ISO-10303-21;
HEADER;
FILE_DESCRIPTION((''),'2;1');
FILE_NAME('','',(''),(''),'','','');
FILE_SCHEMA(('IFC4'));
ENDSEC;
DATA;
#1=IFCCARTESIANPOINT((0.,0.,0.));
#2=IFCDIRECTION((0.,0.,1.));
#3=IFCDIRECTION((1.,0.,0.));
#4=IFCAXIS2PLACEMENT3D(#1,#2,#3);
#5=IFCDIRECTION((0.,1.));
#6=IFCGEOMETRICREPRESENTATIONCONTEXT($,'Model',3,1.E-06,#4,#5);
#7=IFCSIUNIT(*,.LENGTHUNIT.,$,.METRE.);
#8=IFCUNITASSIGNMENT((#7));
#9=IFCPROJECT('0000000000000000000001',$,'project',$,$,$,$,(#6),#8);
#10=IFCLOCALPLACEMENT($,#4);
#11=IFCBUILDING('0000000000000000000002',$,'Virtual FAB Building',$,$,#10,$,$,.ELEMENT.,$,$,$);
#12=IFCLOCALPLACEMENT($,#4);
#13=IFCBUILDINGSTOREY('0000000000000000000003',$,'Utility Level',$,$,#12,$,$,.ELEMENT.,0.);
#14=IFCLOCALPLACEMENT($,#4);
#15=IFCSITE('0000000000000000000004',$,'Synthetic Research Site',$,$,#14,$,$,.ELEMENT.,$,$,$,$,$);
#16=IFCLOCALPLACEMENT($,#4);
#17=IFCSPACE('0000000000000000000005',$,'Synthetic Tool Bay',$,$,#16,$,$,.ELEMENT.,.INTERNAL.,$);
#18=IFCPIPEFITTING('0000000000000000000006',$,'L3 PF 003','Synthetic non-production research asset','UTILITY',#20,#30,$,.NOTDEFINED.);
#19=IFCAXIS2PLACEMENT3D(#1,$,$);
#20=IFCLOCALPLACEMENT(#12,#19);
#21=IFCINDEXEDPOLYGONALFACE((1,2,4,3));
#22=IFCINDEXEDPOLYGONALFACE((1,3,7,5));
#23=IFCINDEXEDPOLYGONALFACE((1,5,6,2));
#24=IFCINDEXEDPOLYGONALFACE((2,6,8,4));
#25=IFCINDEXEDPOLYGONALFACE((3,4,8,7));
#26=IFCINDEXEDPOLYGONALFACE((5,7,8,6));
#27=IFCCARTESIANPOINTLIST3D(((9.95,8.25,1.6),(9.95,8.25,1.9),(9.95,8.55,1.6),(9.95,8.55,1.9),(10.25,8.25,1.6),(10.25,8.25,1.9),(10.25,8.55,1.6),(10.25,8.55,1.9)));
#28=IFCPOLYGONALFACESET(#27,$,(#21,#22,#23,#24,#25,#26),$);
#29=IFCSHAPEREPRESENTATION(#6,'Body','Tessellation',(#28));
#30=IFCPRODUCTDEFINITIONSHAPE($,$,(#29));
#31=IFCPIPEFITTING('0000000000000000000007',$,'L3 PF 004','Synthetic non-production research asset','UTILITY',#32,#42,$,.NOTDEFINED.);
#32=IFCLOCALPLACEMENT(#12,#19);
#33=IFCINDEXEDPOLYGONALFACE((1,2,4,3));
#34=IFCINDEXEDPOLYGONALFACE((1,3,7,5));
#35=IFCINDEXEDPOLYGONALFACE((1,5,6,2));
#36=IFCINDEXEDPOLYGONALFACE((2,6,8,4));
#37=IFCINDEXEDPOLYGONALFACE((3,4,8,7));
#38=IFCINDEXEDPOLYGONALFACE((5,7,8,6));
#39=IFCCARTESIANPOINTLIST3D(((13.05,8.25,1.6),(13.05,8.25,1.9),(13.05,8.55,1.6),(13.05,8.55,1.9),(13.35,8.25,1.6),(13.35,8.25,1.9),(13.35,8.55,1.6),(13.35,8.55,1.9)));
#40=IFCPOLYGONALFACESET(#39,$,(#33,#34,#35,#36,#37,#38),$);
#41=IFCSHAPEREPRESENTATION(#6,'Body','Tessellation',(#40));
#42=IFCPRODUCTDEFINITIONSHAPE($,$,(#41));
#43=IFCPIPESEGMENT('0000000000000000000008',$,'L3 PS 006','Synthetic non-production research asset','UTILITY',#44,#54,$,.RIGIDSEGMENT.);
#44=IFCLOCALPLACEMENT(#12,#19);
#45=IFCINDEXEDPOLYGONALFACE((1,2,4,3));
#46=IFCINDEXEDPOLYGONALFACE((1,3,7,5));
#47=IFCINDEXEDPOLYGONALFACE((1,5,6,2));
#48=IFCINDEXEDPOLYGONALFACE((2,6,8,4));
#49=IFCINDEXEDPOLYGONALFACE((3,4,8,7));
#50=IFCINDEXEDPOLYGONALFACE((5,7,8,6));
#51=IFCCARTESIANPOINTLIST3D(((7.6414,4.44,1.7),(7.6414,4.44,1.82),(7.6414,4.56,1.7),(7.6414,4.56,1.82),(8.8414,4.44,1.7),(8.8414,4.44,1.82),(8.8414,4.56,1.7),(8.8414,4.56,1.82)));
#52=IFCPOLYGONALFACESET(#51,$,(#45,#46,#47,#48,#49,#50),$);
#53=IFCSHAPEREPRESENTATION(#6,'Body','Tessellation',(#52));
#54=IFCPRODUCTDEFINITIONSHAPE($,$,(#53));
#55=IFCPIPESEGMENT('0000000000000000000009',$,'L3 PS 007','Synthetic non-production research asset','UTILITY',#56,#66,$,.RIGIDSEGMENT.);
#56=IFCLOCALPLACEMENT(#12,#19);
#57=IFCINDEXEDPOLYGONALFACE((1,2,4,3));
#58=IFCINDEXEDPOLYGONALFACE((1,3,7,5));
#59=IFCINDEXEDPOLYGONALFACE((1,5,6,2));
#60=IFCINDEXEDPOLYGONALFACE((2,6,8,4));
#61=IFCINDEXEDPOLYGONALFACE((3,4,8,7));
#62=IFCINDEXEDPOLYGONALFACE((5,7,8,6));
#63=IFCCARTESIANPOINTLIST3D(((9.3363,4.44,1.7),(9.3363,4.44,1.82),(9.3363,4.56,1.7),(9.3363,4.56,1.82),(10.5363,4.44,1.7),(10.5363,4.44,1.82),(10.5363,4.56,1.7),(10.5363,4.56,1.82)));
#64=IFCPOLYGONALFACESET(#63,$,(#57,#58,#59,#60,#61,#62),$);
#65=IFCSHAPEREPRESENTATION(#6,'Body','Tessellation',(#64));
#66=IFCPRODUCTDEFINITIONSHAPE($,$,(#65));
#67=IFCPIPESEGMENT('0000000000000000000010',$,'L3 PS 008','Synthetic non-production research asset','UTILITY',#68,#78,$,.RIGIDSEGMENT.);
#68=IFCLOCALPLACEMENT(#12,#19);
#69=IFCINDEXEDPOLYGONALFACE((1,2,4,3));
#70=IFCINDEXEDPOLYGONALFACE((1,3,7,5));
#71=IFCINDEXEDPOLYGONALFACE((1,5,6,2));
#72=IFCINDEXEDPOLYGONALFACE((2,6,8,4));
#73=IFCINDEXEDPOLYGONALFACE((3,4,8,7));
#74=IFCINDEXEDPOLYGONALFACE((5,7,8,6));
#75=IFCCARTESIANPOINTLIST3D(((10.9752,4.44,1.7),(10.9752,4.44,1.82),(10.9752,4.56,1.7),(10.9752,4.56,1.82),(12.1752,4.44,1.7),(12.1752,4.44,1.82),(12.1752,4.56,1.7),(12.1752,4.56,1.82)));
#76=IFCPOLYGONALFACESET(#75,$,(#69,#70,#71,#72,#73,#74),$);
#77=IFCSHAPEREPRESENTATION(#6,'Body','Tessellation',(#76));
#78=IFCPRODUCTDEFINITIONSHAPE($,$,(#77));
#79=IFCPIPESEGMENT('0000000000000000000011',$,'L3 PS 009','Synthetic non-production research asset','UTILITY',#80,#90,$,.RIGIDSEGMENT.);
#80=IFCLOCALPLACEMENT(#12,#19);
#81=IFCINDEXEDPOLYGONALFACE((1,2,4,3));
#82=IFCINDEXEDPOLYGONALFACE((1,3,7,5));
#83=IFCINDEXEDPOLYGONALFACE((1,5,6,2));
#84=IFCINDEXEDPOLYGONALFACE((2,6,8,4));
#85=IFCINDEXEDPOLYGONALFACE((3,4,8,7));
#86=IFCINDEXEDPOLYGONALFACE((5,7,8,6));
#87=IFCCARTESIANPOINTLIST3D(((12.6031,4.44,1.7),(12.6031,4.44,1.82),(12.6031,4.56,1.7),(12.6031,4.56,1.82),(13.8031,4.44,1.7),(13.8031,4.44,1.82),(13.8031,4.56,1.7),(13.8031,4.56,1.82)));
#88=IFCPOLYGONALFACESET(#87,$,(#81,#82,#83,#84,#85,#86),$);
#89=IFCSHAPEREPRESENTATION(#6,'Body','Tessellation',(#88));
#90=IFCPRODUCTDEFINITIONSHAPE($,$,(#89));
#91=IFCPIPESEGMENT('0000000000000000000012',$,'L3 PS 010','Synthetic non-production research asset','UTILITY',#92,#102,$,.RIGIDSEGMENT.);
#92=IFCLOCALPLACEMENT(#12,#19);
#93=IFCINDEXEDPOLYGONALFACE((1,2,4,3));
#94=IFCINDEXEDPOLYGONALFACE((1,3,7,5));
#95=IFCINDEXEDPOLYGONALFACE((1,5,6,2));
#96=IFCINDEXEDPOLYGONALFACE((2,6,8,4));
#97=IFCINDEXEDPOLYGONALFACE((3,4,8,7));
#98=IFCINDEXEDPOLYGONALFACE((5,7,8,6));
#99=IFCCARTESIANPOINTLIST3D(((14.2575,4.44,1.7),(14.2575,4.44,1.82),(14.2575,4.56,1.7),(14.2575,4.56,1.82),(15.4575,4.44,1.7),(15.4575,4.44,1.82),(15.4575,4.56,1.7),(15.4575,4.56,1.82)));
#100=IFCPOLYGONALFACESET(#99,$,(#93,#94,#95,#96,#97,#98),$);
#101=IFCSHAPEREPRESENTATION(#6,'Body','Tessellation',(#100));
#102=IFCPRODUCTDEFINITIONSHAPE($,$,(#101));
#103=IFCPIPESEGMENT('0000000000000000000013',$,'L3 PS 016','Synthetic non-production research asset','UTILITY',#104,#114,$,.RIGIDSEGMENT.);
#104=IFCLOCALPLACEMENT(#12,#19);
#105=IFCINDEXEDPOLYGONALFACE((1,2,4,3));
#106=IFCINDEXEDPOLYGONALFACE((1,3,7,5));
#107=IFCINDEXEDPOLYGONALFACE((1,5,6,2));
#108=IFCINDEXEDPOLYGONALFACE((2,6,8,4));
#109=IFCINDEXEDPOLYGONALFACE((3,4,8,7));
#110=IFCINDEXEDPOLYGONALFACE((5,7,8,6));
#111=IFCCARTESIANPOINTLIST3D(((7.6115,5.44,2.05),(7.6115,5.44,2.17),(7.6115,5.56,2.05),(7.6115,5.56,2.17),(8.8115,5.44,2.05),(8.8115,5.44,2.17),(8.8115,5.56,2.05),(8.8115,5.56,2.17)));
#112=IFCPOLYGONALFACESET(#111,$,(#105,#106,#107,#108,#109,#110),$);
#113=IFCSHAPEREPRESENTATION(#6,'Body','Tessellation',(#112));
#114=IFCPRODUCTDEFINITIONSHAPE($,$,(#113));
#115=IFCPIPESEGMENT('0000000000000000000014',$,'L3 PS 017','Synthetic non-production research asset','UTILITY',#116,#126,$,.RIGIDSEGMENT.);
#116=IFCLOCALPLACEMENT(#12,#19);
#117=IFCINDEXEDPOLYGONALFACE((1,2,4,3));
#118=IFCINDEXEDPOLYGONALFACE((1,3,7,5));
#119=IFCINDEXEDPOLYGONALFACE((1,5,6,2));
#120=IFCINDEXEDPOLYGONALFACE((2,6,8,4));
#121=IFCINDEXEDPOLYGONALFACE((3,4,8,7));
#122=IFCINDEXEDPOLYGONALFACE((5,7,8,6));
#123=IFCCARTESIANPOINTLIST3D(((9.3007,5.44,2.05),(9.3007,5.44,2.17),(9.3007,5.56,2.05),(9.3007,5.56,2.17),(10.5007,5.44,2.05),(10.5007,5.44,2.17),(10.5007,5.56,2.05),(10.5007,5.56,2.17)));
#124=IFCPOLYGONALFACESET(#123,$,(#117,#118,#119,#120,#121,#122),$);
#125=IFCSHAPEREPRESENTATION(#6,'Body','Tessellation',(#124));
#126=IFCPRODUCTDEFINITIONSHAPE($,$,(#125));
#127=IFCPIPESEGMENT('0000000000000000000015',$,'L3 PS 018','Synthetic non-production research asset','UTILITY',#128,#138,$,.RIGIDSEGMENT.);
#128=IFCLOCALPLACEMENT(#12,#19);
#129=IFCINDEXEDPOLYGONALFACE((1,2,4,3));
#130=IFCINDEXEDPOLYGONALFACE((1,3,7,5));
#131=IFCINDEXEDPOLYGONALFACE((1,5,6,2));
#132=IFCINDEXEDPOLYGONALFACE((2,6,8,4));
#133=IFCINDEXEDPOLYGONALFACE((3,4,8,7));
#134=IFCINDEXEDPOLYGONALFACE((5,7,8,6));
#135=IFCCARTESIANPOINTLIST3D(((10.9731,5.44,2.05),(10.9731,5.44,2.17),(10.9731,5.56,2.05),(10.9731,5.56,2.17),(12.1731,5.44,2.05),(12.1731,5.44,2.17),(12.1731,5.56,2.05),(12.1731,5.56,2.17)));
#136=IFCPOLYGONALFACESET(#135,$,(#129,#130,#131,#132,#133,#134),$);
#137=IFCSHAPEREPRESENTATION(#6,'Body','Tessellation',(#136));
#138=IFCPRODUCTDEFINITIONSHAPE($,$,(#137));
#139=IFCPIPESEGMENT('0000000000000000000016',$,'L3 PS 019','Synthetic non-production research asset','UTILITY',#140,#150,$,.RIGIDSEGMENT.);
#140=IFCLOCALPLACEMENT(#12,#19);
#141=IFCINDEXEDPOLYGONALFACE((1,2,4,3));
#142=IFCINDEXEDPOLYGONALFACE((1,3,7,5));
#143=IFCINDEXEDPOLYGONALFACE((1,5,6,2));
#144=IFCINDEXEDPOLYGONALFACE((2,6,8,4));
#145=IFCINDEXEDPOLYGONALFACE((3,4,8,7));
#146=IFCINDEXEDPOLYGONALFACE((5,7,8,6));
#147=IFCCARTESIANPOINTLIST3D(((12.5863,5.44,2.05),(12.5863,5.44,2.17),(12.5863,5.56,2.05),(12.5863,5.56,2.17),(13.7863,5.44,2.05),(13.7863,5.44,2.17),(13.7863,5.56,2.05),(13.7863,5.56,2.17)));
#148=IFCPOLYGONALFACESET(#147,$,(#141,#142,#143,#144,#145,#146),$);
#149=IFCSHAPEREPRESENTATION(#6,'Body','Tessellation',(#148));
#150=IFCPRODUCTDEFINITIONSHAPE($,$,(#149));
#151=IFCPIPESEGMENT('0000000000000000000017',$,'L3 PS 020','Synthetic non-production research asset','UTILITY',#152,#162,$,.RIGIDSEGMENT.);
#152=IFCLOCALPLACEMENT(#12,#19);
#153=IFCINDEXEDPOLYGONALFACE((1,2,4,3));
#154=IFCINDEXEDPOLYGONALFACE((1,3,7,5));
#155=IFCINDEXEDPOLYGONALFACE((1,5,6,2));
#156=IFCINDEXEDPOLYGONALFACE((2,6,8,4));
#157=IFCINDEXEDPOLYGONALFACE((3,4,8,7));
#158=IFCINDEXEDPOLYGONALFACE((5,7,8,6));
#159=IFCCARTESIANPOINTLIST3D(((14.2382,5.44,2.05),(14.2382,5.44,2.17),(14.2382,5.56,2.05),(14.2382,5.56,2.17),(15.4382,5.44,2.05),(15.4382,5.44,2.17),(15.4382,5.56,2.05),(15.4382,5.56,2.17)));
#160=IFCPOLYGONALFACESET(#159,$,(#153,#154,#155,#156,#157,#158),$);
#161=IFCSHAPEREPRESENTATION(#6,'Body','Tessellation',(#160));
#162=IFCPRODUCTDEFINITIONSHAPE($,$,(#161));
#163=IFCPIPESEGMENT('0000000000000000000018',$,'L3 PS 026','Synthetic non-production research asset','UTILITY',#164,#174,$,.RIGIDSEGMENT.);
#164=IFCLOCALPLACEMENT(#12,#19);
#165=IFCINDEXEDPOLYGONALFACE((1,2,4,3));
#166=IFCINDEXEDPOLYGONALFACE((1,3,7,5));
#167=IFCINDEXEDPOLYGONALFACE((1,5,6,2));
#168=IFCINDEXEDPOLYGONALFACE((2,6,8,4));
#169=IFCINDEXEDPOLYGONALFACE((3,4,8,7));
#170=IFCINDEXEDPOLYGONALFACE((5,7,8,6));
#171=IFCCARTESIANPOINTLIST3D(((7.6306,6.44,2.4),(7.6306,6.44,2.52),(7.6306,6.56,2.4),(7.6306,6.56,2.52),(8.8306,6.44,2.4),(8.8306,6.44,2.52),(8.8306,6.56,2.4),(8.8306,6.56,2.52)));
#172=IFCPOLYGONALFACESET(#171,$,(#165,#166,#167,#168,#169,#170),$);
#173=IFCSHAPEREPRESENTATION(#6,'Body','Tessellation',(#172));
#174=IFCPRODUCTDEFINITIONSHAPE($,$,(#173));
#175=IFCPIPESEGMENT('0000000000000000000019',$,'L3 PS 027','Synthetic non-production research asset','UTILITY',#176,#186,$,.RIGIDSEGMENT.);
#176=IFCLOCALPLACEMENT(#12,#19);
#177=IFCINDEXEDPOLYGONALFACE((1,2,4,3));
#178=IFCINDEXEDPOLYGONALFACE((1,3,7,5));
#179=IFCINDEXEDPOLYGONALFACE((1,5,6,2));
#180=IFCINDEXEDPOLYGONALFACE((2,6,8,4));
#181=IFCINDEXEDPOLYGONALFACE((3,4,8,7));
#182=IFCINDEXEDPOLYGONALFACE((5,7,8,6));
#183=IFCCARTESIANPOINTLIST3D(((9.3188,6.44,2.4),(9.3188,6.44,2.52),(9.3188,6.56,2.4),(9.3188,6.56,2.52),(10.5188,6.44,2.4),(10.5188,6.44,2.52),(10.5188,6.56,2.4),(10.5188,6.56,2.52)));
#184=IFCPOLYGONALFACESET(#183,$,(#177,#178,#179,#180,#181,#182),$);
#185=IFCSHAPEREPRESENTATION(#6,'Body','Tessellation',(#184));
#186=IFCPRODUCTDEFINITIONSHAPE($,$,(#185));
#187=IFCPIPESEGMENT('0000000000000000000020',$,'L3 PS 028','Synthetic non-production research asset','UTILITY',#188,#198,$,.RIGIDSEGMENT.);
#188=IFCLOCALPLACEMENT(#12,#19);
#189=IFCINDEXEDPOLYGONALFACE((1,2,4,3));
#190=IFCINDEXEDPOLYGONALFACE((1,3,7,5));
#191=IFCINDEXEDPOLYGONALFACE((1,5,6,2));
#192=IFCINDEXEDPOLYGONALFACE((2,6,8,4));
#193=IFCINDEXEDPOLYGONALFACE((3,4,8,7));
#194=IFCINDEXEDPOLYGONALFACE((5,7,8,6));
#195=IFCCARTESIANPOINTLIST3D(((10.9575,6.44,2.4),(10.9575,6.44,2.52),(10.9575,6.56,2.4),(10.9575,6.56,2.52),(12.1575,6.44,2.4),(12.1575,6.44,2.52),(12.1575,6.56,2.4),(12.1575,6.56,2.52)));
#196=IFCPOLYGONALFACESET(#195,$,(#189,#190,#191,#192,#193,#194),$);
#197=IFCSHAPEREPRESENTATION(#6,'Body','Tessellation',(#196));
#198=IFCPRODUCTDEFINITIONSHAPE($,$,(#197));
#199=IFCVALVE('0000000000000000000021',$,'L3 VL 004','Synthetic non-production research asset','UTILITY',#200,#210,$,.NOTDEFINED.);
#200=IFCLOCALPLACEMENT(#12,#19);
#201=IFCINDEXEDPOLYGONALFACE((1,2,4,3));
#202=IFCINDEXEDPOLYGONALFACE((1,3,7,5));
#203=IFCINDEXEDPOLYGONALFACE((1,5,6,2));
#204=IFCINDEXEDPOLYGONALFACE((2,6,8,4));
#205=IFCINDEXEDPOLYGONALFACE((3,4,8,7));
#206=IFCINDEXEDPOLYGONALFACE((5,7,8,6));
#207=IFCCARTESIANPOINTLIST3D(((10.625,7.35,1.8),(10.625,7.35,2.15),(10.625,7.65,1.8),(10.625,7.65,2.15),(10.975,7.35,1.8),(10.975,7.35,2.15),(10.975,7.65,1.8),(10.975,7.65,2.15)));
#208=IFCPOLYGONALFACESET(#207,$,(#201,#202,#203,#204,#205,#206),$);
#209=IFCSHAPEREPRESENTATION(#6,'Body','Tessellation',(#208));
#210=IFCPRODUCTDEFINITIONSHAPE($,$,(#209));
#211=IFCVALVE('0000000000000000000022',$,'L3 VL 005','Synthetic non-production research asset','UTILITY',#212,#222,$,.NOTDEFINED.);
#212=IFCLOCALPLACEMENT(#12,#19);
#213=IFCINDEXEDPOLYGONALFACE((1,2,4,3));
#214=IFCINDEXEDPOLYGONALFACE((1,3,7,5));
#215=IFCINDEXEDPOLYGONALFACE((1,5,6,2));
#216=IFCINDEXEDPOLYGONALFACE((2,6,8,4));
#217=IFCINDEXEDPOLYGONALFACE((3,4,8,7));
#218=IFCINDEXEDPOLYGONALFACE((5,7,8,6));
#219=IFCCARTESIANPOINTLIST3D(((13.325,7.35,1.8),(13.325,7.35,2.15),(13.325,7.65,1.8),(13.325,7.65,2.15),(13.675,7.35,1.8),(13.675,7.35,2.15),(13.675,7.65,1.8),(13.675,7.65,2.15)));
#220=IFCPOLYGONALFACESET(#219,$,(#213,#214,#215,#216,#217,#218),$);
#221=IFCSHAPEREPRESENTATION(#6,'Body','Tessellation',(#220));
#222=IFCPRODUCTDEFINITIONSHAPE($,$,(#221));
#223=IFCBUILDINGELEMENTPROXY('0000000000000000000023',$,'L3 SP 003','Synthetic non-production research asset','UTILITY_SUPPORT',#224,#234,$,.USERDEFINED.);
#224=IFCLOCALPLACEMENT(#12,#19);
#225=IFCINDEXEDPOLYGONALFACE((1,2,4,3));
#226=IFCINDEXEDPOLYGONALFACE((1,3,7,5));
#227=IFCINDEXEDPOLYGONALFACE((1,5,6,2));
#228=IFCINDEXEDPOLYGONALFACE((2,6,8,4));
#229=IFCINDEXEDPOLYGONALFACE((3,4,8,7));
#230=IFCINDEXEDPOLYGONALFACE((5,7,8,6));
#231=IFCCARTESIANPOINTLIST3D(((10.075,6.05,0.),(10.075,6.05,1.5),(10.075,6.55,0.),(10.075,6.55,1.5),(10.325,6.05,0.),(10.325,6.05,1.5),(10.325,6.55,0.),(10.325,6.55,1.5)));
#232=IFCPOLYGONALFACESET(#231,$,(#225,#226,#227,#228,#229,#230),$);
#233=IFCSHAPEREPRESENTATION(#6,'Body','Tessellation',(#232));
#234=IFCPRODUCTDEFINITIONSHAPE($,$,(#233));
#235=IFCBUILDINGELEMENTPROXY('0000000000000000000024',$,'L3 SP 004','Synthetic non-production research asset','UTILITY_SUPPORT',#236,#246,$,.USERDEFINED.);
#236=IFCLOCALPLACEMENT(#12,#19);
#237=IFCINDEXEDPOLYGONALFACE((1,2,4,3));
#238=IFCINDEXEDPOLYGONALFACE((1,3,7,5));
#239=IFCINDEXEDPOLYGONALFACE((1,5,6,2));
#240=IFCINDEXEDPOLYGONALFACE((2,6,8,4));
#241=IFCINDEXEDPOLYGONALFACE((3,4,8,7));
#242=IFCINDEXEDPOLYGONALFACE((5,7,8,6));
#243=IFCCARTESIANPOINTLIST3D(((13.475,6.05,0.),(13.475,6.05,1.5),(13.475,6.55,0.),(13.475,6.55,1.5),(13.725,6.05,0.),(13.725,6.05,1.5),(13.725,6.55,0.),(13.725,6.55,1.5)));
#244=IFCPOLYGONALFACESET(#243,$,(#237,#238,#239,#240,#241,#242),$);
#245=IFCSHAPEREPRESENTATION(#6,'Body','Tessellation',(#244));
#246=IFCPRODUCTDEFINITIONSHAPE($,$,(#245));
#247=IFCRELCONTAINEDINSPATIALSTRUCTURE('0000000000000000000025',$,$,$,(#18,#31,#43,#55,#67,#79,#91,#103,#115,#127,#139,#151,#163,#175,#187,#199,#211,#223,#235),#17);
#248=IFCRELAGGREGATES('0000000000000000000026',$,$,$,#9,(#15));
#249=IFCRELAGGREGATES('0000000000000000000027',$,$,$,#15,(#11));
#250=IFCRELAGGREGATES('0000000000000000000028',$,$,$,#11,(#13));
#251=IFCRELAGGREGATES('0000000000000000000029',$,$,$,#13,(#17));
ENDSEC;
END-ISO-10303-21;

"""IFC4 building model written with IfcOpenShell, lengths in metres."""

from ifc_helpers import new_model, si_unit, direction, frame, origin_with_axes, origin_2d_with_axis, place, context, project, spatial, rectangle, extrude, element, save


model = new_model("IFC4")

# Units and contexts
model_context = context("Model", 3, precision=1e-06, world=origin_with_axes(), true_north=direction((0.0, 1.0)))
ifc_project = project(units=[si_unit("LENGTHUNIT", "METRE")], contexts=[model_context])

# Site, building, storey, space
site_placement = place(None, origin_with_axes())
site = spatial("IfcSite", under=ifc_project, at=site_placement, Name="Synthetic Research Site", CompositionType="ELEMENT")
building_placement = place(None, origin_with_axes())
building = spatial("IfcBuilding", under=site, at=building_placement, Name="Virtual FAB Building", CompositionType="ELEMENT")
storey_placement = place(None, origin_with_axes())
storey = spatial("IfcBuildingStorey", under=building, at=storey_placement, Name="Utility Level", CompositionType="ELEMENT", Elevation=0.0)
space_placement = place(None, origin_with_axes())
space = spatial("IfcSpace", under=storey, at=space_placement, Name="Synthetic Tool Bay", CompositionType="ELEMENT", PredefinedType="INTERNAL")

# Pipe fittings
for number, where, z_axis, x_axis, name in (
    (1, (10.1, 8.4, 1.6), (0.0, 0.0, 1.0), (1.0, 0.0, 0.0), "L3 PF 003"),
    (2, (13.2, 8.4, 1.6), (0.0, 0.0, 1.0), (1.0, 0.0, 0.0), "L3 PF 004"),
):
    element("IfcPipeFitting", number, at=place(None, frame(where, z_axis=z_axis, x_axis=x_axis)), inside=space, Name=name, Description="Synthetic non-production research asset", ObjectType="UTILITY", PredefinedType="NOTDEFINED", context=model_context, shape_type="SweptSolid", body=[
        extrude(rectangle(XDim=0.3, YDim=0.3, at=origin_2d_with_axis()), origin_with_axes(), (0.0, 0.0, 1.0), 0.3),
    ])

# Pipe segments
for number, where, z_axis, x_axis, name in (
    (3, (8.2414, 4.5, 1.7), (0.0, 0.0, 1.0), (1.0, 0.0, 0.0), "L3 PS 006"),
    (4, (9.9363, 4.5, 1.7), (0.0, 0.0, 1.0), (1.0, 0.0, 0.0), "L3 PS 007"),
    (5, (11.5752, 4.5, 1.7), (0.0, 0.0, 1.0), (1.0, 0.0, 0.0), "L3 PS 008"),
    (6, (13.2031, 4.5, 1.7), (0.0, 0.0, 1.0), (1.0, 0.0, 0.0), "L3 PS 009"),
    (7, (14.8575, 4.5, 1.7), (0.0, 0.0, 1.0), (1.0, 0.0, 0.0), "L3 PS 010"),
    (8, (8.2115, 5.5, 2.05), (0.0, 0.0, 1.0), (1.0, 0.0, 0.0), "L3 PS 016"),
    (9, (9.9007, 5.5, 2.05), (0.0, 0.0, 1.0), (1.0, 0.0, 0.0), "L3 PS 017"),
    (10, (11.5731, 5.5, 2.05), (0.0, 0.0, 1.0), (1.0, 0.0, 0.0), "L3 PS 018"),
    (11, (13.1863, 5.5, 2.05), (0.0, 0.0, 1.0), (1.0, 0.0, 0.0), "L3 PS 019"),
    (12, (14.8382, 5.5, 2.05), (0.0, 0.0, 1.0), (1.0, 0.0, 0.0), "L3 PS 020"),
    (13, (8.2306, 6.5, 2.4), (0.0, 0.0, 1.0), (1.0, 0.0, 0.0), "L3 PS 026"),
    (14, (9.9188, 6.5, 2.4), (0.0, 0.0, 1.0), (1.0, 0.0, 0.0), "L3 PS 027"),
    (15, (11.5575, 6.5, 2.4), (0.0, 0.0, 1.0), (1.0, 0.0, 0.0), "L3 PS 028"),
):
    element("IfcPipeSegment", number, at=place(None, frame(where, z_axis=z_axis, x_axis=x_axis)), inside=space, Name=name, Description="Synthetic non-production research asset", ObjectType="UTILITY", PredefinedType="RIGIDSEGMENT", context=model_context, shape_type="SweptSolid", body=[
        extrude(rectangle(XDim=1.2, YDim=0.12, at=origin_2d_with_axis()), origin_with_axes(), (0.0, 0.0, 1.0), 0.12),
    ])

# Valves
for number, where, z_axis, x_axis, name in (
    (16, (10.8, 7.5, 1.8), (0.0, 0.0, 1.0), (1.0, 0.0, 0.0), "L3 VL 004"),
    (17, (13.5, 7.5, 1.8), (0.0, 0.0, 1.0), (1.0, 0.0, 0.0), "L3 VL 005"),
):
    element("IfcValve", number, at=place(None, frame(where, z_axis=z_axis, x_axis=x_axis)), inside=space, Name=name, Description="Synthetic non-production research asset", ObjectType="UTILITY", PredefinedType="NOTDEFINED", context=model_context, shape_type="SweptSolid", body=[
        extrude(rectangle(XDim=0.35, YDim=0.3, at=origin_2d_with_axis()), origin_with_axes(), (0.0, 0.0, 1.0), 0.35),
    ])

# Building element proxies
for number, where, z_axis, x_axis, name in (
    (18, (10.2, 6.3, 0.0), (0.0, 0.0, 1.0), (1.0, 0.0, 0.0), "L3 SP 003"),
    (19, (13.6, 6.3, 0.0), (0.0, 0.0, 1.0), (1.0, 0.0, 0.0), "L3 SP 004"),
):
    element("IfcBuildingElementProxy", number, at=place(None, frame(where, z_axis=z_axis, x_axis=x_axis)), inside=space, Name=name, Description="Synthetic non-production research asset", ObjectType="UTILITY_SUPPORT", PredefinedType="USERDEFINED", context=model_context, shape_type="SweptSolid", body=[
        extrude(rectangle(XDim=0.25, YDim=0.5, at=origin_2d_with_axis()), origin_with_axes(), (0.0, 0.0, 1.0), 1.5),
    ])

save(model, "model.ifc")
